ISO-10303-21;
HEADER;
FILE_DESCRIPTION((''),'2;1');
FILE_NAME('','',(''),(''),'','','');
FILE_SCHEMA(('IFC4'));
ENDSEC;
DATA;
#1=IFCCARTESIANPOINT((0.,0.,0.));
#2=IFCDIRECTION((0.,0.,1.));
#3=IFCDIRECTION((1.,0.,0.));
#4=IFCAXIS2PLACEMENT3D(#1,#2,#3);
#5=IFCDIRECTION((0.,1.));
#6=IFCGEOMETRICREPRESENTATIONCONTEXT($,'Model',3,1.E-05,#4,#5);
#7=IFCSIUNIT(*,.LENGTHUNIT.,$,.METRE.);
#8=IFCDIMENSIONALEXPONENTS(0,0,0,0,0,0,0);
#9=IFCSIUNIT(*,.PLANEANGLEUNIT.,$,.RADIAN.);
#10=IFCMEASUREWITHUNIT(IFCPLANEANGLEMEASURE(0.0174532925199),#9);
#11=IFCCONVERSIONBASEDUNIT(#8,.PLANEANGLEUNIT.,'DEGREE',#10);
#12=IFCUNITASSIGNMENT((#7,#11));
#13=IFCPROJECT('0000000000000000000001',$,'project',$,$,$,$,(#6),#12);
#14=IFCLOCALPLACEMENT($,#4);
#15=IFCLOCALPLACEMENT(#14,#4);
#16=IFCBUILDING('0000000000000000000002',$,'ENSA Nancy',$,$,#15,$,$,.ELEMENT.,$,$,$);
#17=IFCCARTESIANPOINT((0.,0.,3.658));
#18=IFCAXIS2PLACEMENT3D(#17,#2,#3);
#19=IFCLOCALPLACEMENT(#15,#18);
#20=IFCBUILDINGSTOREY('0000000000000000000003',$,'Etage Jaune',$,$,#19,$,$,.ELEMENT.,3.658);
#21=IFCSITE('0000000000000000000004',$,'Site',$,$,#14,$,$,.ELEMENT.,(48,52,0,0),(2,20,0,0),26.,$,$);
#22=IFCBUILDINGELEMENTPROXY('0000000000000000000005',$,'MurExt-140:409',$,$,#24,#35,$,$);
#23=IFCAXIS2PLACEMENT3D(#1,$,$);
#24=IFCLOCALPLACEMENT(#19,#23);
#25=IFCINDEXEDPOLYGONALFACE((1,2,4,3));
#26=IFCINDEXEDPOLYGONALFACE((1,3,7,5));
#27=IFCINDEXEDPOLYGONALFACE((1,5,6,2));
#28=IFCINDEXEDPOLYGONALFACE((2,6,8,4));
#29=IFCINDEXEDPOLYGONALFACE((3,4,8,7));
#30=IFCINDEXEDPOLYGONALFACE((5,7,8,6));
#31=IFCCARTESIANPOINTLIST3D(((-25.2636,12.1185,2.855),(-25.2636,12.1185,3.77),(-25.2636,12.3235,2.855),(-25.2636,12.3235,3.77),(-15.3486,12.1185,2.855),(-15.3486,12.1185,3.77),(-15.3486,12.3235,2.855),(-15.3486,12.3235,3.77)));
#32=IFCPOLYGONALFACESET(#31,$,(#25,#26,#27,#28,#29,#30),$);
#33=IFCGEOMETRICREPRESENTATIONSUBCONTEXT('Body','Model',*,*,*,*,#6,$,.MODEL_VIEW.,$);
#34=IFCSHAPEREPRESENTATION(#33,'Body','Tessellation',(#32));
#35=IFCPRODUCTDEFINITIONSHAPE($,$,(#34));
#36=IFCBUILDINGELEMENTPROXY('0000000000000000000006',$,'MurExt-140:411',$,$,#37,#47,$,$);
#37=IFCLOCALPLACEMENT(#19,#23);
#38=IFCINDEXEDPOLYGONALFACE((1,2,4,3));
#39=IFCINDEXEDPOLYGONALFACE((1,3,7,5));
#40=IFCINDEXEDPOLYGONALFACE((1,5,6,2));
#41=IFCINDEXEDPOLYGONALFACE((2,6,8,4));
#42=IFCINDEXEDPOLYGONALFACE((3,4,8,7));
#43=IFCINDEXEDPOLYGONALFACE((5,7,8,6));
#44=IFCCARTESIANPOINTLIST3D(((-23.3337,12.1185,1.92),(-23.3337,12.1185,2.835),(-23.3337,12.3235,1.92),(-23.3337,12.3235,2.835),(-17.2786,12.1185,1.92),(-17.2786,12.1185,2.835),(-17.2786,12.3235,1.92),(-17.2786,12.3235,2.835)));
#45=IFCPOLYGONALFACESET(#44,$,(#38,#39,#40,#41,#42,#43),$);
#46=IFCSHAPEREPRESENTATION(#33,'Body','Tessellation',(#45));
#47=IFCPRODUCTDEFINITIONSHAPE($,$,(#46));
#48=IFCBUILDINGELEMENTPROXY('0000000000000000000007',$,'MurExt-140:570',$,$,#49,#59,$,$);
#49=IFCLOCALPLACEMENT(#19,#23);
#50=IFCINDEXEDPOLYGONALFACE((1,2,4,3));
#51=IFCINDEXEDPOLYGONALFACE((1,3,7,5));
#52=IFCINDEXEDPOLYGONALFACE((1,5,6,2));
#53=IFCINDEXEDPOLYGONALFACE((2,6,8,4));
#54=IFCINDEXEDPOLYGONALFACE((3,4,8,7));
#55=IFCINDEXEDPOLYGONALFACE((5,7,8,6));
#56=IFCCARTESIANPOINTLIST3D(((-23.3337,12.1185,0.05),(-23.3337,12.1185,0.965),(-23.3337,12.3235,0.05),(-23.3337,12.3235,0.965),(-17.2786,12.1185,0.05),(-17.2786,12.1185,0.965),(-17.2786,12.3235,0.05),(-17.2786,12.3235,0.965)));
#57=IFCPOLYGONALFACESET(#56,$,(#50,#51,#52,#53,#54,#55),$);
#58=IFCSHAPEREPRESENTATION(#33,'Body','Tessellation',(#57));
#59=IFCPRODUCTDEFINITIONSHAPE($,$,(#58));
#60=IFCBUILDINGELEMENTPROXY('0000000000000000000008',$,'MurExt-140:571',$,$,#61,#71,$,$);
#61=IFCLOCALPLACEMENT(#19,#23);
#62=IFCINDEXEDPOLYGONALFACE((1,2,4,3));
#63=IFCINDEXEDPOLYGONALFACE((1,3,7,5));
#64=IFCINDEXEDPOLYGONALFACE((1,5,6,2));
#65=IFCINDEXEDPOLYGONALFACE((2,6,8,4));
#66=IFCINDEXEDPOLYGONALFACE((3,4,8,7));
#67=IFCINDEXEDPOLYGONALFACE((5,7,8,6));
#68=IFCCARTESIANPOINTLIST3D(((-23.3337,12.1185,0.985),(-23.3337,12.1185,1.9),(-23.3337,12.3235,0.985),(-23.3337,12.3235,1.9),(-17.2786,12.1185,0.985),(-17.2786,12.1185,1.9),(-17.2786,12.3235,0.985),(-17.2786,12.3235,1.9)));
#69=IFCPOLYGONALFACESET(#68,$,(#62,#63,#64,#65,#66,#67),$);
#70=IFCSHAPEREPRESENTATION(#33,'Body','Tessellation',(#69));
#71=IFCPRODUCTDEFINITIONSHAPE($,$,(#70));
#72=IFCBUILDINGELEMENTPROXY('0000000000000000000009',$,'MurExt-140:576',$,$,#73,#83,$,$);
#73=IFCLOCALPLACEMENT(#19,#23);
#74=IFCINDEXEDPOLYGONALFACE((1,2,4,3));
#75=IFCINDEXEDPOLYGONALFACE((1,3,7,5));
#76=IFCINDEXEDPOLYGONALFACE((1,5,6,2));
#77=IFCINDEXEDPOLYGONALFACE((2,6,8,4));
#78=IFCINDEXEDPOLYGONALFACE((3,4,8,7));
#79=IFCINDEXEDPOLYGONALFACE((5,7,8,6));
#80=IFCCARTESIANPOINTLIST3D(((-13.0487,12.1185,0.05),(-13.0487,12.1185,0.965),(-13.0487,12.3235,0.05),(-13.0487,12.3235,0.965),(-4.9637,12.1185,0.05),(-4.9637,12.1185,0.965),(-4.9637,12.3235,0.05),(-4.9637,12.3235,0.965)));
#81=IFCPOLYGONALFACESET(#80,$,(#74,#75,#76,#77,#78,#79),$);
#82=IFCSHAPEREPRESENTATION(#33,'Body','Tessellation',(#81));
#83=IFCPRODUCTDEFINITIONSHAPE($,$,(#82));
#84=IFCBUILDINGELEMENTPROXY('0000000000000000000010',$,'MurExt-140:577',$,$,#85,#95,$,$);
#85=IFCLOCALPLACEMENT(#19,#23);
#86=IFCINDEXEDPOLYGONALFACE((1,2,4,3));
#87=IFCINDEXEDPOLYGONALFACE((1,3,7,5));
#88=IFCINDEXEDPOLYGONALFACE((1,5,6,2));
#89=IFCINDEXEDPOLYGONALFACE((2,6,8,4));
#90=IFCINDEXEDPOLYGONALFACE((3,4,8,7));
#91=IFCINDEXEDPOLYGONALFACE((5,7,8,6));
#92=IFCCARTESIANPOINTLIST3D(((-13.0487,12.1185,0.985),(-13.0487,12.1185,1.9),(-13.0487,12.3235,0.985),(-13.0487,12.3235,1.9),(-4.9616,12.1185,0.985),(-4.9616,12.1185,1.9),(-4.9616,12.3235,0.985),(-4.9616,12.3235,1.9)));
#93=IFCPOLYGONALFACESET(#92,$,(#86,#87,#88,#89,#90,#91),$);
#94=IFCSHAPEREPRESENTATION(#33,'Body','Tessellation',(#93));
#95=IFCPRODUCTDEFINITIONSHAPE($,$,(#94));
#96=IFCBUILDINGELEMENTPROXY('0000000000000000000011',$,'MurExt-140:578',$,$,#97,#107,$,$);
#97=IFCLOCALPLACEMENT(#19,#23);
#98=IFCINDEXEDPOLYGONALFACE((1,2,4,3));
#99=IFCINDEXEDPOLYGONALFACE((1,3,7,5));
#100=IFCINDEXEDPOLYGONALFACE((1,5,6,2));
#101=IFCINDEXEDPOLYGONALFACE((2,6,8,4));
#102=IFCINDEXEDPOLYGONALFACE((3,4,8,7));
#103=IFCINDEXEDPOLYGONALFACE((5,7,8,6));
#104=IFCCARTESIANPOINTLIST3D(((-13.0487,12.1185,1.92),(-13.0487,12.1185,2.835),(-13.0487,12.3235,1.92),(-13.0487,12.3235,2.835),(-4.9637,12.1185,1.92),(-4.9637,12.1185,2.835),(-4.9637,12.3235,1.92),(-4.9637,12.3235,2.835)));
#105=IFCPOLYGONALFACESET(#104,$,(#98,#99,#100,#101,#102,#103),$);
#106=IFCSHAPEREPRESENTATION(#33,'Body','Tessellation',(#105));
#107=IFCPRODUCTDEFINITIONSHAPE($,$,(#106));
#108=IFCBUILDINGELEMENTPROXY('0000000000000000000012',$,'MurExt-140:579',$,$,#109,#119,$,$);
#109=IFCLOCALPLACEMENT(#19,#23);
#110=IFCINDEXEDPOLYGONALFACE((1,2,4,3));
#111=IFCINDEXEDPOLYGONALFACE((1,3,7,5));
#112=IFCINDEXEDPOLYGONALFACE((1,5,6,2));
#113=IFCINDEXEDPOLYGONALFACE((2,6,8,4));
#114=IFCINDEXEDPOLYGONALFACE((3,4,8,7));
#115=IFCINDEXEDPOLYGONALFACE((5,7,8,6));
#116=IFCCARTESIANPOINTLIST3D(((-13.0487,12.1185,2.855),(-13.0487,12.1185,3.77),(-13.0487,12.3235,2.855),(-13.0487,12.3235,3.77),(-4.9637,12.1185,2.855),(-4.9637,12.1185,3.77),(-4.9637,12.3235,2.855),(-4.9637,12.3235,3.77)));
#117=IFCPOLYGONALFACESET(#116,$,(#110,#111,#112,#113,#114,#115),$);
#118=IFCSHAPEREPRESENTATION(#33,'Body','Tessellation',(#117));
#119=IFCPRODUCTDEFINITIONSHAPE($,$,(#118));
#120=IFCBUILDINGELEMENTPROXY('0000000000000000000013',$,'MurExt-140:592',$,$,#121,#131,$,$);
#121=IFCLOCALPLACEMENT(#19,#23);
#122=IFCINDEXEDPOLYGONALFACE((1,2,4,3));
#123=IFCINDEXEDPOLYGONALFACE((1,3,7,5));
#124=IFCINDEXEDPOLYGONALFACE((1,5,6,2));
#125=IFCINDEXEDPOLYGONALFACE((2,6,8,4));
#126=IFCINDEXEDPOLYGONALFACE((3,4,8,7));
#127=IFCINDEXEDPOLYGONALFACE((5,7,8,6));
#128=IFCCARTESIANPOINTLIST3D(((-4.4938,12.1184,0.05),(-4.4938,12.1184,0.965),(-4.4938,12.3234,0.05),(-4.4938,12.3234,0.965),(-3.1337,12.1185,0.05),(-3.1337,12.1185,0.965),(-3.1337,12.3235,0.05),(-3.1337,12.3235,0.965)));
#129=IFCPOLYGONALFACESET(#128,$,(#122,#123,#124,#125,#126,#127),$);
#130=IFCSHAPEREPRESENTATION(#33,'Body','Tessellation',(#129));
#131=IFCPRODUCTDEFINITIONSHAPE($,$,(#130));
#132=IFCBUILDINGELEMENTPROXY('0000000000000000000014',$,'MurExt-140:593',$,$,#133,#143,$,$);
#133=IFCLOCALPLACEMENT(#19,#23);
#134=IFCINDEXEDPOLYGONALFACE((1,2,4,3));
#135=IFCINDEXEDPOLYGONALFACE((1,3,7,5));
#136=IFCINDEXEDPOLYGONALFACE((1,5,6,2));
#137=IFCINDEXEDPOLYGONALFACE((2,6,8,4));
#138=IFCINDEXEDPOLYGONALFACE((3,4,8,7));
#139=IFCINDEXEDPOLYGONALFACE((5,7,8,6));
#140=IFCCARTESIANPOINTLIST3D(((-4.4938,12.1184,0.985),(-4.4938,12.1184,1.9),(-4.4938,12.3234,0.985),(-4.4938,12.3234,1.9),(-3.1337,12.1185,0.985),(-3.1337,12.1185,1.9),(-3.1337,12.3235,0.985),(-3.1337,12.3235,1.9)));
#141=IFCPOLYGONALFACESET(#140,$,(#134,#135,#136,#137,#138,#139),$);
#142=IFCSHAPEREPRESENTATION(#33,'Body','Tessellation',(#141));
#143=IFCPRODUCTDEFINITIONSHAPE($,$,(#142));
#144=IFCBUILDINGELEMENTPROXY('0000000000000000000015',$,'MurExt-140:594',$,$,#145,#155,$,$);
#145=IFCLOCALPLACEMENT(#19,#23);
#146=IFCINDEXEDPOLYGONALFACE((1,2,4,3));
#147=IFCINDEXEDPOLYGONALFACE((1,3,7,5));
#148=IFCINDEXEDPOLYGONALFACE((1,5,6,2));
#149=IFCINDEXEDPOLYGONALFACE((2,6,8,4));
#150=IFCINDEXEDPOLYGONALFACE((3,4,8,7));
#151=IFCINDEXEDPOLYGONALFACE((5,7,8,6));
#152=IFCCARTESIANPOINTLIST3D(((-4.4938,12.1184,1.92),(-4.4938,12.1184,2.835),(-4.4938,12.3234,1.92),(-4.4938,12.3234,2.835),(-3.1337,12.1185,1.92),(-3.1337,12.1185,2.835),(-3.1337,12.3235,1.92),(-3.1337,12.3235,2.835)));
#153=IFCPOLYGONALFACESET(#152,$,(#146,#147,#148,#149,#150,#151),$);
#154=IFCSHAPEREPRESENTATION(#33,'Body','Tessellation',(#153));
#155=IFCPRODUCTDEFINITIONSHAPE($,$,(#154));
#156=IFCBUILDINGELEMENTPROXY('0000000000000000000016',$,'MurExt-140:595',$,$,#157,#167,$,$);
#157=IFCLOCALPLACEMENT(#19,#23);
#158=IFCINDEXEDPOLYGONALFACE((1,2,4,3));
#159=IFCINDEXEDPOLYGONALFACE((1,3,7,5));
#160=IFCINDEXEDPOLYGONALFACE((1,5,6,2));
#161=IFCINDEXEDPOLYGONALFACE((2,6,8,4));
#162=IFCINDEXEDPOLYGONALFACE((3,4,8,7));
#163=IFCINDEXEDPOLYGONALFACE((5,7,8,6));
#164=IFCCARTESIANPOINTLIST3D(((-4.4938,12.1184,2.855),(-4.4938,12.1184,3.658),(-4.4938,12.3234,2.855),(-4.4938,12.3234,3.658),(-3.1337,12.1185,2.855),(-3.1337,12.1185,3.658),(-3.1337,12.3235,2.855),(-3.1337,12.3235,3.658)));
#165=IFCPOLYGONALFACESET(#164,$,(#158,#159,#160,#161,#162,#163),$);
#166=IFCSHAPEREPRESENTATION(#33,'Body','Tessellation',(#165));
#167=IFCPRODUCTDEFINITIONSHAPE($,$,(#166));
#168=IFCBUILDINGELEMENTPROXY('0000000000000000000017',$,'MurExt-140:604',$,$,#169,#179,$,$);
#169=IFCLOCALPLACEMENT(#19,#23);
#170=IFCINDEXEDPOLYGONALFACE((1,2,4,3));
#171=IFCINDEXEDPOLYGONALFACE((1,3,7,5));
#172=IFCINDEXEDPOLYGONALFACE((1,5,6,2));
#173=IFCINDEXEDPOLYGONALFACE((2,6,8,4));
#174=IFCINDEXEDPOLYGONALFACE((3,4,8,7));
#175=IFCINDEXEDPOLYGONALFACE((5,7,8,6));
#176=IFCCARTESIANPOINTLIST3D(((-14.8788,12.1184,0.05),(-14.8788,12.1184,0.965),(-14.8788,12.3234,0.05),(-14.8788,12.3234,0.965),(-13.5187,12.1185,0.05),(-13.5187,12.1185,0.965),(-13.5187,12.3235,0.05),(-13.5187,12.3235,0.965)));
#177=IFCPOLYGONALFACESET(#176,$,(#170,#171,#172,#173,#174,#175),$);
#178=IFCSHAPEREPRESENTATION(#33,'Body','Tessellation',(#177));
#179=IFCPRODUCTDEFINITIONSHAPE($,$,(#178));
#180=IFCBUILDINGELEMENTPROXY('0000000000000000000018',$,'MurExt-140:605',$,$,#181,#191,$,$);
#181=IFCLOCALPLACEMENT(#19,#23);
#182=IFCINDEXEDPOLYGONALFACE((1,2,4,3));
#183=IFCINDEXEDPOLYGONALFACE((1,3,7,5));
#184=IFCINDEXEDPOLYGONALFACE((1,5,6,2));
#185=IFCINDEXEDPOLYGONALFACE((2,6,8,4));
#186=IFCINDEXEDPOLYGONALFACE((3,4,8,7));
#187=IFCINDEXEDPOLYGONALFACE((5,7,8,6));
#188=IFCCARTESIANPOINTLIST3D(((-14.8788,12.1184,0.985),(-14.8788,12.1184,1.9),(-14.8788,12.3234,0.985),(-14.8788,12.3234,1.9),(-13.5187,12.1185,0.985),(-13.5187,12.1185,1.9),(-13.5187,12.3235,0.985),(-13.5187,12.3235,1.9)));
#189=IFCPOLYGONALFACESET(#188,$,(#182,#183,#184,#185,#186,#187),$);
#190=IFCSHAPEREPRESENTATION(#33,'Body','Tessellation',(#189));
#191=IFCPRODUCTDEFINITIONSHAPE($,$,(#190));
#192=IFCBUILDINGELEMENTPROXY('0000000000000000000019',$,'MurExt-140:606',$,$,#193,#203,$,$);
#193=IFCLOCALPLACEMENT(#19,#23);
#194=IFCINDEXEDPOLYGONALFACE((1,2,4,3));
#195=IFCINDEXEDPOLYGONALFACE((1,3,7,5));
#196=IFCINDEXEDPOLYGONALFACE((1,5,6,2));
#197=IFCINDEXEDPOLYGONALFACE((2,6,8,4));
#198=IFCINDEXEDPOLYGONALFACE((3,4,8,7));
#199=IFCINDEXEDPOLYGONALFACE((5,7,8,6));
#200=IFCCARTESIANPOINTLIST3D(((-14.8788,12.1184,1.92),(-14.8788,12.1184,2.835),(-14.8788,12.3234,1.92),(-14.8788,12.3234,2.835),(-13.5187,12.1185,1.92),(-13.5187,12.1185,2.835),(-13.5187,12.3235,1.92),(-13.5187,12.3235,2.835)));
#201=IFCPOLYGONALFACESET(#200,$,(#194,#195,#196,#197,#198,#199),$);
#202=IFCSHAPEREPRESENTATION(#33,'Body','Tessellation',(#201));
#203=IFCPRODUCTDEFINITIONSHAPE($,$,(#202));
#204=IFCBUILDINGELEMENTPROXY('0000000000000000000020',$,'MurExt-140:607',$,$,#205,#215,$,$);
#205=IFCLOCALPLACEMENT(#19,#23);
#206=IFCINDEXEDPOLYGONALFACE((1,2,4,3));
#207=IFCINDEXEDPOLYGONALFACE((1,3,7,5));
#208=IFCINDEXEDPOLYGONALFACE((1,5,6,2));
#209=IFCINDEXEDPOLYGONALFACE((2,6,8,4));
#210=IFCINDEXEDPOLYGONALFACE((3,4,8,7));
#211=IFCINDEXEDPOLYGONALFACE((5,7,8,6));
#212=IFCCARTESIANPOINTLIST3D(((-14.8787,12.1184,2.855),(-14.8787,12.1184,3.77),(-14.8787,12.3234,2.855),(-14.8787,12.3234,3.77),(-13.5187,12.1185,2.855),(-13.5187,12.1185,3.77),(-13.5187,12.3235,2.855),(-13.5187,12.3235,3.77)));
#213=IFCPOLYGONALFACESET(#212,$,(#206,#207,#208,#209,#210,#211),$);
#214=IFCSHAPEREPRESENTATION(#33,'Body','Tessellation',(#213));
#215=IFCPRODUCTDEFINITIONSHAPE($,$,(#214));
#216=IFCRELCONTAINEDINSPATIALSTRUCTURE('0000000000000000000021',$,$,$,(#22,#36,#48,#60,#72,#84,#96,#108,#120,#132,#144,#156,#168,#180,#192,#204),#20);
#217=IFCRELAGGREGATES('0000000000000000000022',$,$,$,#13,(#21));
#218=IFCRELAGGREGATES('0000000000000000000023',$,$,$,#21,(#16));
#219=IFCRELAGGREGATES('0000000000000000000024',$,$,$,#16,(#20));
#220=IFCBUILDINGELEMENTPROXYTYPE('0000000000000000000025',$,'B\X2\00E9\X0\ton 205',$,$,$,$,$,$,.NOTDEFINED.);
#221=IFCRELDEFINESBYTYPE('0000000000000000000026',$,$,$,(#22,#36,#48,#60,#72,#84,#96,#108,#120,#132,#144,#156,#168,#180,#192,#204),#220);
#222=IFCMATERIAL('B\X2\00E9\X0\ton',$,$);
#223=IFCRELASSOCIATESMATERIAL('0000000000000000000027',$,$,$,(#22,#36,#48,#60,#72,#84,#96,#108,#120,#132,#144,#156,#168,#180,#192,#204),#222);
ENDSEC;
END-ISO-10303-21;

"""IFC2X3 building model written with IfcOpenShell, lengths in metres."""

from ifc_helpers import new_model, entity, si_unit, converted_unit, direction, frame, origin_with_axes, place, context, subcontext, project, spatial, polyline, outline, extrude, material, type_object, element, save


model = new_model("IFC2X3")

# Units and contexts
model_context = context("Model", 3, precision=1e-05, world=origin_with_axes(), true_north=direction((0.0, 1.0)))
body_context = subcontext(model_context, "Body", "Model", "MODEL_VIEW")
ifc_project = project(units=[si_unit("LENGTHUNIT", "METRE"), converted_unit("PLANEANGLEUNIT", "DEGREE", entity("IfcPlaneAngleMeasure", 0.0174532925199), si_unit("PLANEANGLEUNIT", "RADIAN"), dimensions=[0, 0, 0, 0, 0, 0, 0])], contexts=[model_context])

# Site, building, storey
site_placement = place(None, origin_with_axes())
site = spatial("IfcSite", under=ifc_project, at=site_placement, Name="Site", CompositionType="ELEMENT", RefLatitude=(48, 52, 0, 0), RefLongitude=(2, 20, 0, 0), RefElevation=26.0)
building_placement = place(site_placement, origin_with_axes())
building = spatial("IfcBuilding", under=site, at=building_placement, Name="ENSA Nancy", CompositionType="ELEMENT")
storey_placement = place(building_placement, frame((0.0, 0.0, 3.658), z_axis=(0.0, 0.0, 1.0), x_axis=(1.0, 0.0, 0.0)))
storey = spatial("IfcBuildingStorey", under=building, at=storey_placement, Name="Etage Jaune", CompositionType="ELEMENT", Elevation=3.658)

# Building element proxies
ifc_material = material(Name="Béton")
building_element_proxy_type_1 = type_object("IfcBuildingElementProxyType", Name="Béton 205", PredefinedType="NOTDEFINED")
proxy_1_placement = place(storey_placement, frame((-25.2636, 12.3235, 2.855), z_axis=(0.0, 0.0, 1.0), x_axis=(1.0, 0.0, 0.0)))
element("IfcBuildingElementProxy", 1, at=proxy_1_placement, inside=storey, type_object=building_element_proxy_type_1, material=ifc_material, Name="MurExt-140:409", context=body_context, shape_type="SweptSolid", body=[
    extrude(outline(polyline([(0.0, -0.205), (9.915, -0.205), (9.915, 0.0), (0.0, 0.0), (0.0, -0.205)])), origin_with_axes(), (0.0, 0.0, 1.0), 0.915),
])
for number, where, z_axis, x_axis, name in (
    (2, (-23.3337, 12.3235, 1.92), (0.0, 0.0, 1.0), (1.0, 0.0, 0.0), "MurExt-140:411"),
    (3, (-23.3337, 12.3235, 0.05), (0.0, 0.0, 1.0), (1.0, 0.0, 0.0), "MurExt-140:570"),
    (4, (-23.3337, 12.3235, 0.985), (0.0, 0.0, 1.0), (1.0, 0.0, 0.0), "MurExt-140:571"),
):
    element("IfcBuildingElementProxy", number, at=place(storey_placement, frame(where, z_axis=z_axis, x_axis=x_axis)), inside=storey, type_object=building_element_proxy_type_1, material=ifc_material, Name=name, context=body_context, shape_type="SweptSolid", body=[
        extrude(outline(polyline([(0.0, -0.205), (6.055, -0.205), (6.055, 0.0), (0.0, 0.0), (0.0, -0.205)])), origin_with_axes(), (0.0, 0.0, 1.0), 0.915),
    ])
proxy_2_placement = place(storey_placement, frame((-13.0487, 12.3235, 0.05), z_axis=(0.0, 0.0, 1.0), x_axis=(1.0, 0.0, 0.0)))
element("IfcBuildingElementProxy", 5, at=proxy_2_placement, inside=storey, type_object=building_element_proxy_type_1, material=ifc_material, Name="MurExt-140:576", context=body_context, shape_type="SweptSolid", body=[
    extrude(outline(polyline([(0.0, -0.205), (8.085, -0.205), (8.085, 0.0), (0.0, 0.0), (0.0, -0.205)])), origin_with_axes(), (0.0, 0.0, 1.0), 0.915),
])
proxy_3_placement = place(storey_placement, frame((-13.0487, 12.3235, 0.985), z_axis=(0.0, 0.0, 1.0), x_axis=(1.0, 0.0, 0.0)))
element("IfcBuildingElementProxy", 6, at=proxy_3_placement, inside=storey, type_object=building_element_proxy_type_1, material=ifc_material, Name="MurExt-140:577", context=body_context, shape_type="SweptSolid", body=[
    extrude(outline(polyline([(0.0, -0.205), (8.087, -0.205), (8.087, 0.0), (0.0, 0.0), (0.0, -0.205)])), origin_with_axes(), (0.0, 0.0, 1.0), 0.915),
])
for number, where, z_axis, x_axis, name in (
    (7, (-13.0487, 12.3235, 1.92), (0.0, 0.0, 1.0), (1.0, 0.0, 0.0), "MurExt-140:578"),
    (8, (-13.0487, 12.3235, 2.855), (0.0, 0.0, 1.0), (1.0, 0.0, 0.0), "MurExt-140:579"),
):
    element("IfcBuildingElementProxy", number, at=place(storey_placement, frame(where, z_axis=z_axis, x_axis=x_axis)), inside=storey, type_object=building_element_proxy_type_1, material=ifc_material, Name=name, context=body_context, shape_type="SweptSolid", body=[
        extrude(outline(polyline([(0.0, -0.205), (8.085, -0.205), (8.085, 0.0), (0.0, 0.0), (0.0, -0.205)])), origin_with_axes(), (0.0, 0.0, 1.0), 0.915),
    ])
for number, where, z_axis, x_axis, name in (
    (9, (-4.4938, 12.3234, 0.05), (0.0, 0.0, 1.0), (1.0, 0.000034, 0.0), "MurExt-140:592"),
    (10, (-4.4938, 12.3234, 0.985), (0.0, 0.0, 1.0), (1.0, 0.000034, 0.0), "MurExt-140:593"),
    (11, (-4.4938, 12.3234, 1.92), (0.0, 0.0, 1.0), (1.0, 0.000034, 0.0), "MurExt-140:594"),
):
    element("IfcBuildingElementProxy", number, at=place(storey_placement, frame(where, z_axis=z_axis, x_axis=x_axis)), inside=storey, type_object=building_element_proxy_type_1, material=ifc_material, Name=name, context=body_context, shape_type="SweptSolid", body=[
        extrude(outline(polyline([(0.0, -0.205), (1.3601, -0.205), (1.3601, 0.0), (0.0, 0.0), (0.0, -0.205)])), origin_with_axes(), (0.0, 0.0, 1.0), 0.915),
    ])
proxy_4_placement = place(storey_placement, frame((-4.4938, 12.3234, 2.855), z_axis=(0.0, 0.0, 1.0), x_axis=(1.0, 0.000034, 0.0)))
element("IfcBuildingElementProxy", 12, at=proxy_4_placement, inside=storey, type_object=building_element_proxy_type_1, material=ifc_material, Name="MurExt-140:595", context=body_context, shape_type="SweptSolid", body=[
    extrude(outline(polyline([(0.0, -0.205), (1.3601, -0.205), (1.3601, 0.0), (0.0, 0.0), (0.0, -0.205)])), origin_with_axes(), (0.0, 0.0, 1.0), 0.803),
])
for number, where, z_axis, x_axis, name in (
    (13, (-14.8788, 12.3234, 0.05), (0.0, 0.0, 1.0), (1.0, 0.000034, 0.0), "MurExt-140:604"),
    (14, (-14.8788, 12.3234, 0.985), (0.0, 0.0, 1.0), (1.0, 0.000034, 0.0), "MurExt-140:605"),
    (15, (-14.8788, 12.3234, 1.92), (0.0, 0.0, 1.0), (1.0, 0.000034, 0.0), "MurExt-140:606"),
    (16, (-14.8787, 12.3234, 2.855), (0.0, 0.0, 1.0), (1.0, 0.000034, 0.0), "MurExt-140:607"),
):
    element("IfcBuildingElementProxy", number, at=place(storey_placement, frame(where, z_axis=z_axis, x_axis=x_axis)), inside=storey, type_object=building_element_proxy_type_1, material=ifc_material, Name=name, context=body_context, shape_type="SweptSolid", body=[
        extrude(outline(polyline([(0.0, -0.205), (1.3601, -0.205), (1.3601, 0.0), (0.0, 0.0), (0.0, -0.205)])), origin_with_axes(), (0.0, 0.0, 1.0), 0.915),
    ])

save(model, "model.ifc")
